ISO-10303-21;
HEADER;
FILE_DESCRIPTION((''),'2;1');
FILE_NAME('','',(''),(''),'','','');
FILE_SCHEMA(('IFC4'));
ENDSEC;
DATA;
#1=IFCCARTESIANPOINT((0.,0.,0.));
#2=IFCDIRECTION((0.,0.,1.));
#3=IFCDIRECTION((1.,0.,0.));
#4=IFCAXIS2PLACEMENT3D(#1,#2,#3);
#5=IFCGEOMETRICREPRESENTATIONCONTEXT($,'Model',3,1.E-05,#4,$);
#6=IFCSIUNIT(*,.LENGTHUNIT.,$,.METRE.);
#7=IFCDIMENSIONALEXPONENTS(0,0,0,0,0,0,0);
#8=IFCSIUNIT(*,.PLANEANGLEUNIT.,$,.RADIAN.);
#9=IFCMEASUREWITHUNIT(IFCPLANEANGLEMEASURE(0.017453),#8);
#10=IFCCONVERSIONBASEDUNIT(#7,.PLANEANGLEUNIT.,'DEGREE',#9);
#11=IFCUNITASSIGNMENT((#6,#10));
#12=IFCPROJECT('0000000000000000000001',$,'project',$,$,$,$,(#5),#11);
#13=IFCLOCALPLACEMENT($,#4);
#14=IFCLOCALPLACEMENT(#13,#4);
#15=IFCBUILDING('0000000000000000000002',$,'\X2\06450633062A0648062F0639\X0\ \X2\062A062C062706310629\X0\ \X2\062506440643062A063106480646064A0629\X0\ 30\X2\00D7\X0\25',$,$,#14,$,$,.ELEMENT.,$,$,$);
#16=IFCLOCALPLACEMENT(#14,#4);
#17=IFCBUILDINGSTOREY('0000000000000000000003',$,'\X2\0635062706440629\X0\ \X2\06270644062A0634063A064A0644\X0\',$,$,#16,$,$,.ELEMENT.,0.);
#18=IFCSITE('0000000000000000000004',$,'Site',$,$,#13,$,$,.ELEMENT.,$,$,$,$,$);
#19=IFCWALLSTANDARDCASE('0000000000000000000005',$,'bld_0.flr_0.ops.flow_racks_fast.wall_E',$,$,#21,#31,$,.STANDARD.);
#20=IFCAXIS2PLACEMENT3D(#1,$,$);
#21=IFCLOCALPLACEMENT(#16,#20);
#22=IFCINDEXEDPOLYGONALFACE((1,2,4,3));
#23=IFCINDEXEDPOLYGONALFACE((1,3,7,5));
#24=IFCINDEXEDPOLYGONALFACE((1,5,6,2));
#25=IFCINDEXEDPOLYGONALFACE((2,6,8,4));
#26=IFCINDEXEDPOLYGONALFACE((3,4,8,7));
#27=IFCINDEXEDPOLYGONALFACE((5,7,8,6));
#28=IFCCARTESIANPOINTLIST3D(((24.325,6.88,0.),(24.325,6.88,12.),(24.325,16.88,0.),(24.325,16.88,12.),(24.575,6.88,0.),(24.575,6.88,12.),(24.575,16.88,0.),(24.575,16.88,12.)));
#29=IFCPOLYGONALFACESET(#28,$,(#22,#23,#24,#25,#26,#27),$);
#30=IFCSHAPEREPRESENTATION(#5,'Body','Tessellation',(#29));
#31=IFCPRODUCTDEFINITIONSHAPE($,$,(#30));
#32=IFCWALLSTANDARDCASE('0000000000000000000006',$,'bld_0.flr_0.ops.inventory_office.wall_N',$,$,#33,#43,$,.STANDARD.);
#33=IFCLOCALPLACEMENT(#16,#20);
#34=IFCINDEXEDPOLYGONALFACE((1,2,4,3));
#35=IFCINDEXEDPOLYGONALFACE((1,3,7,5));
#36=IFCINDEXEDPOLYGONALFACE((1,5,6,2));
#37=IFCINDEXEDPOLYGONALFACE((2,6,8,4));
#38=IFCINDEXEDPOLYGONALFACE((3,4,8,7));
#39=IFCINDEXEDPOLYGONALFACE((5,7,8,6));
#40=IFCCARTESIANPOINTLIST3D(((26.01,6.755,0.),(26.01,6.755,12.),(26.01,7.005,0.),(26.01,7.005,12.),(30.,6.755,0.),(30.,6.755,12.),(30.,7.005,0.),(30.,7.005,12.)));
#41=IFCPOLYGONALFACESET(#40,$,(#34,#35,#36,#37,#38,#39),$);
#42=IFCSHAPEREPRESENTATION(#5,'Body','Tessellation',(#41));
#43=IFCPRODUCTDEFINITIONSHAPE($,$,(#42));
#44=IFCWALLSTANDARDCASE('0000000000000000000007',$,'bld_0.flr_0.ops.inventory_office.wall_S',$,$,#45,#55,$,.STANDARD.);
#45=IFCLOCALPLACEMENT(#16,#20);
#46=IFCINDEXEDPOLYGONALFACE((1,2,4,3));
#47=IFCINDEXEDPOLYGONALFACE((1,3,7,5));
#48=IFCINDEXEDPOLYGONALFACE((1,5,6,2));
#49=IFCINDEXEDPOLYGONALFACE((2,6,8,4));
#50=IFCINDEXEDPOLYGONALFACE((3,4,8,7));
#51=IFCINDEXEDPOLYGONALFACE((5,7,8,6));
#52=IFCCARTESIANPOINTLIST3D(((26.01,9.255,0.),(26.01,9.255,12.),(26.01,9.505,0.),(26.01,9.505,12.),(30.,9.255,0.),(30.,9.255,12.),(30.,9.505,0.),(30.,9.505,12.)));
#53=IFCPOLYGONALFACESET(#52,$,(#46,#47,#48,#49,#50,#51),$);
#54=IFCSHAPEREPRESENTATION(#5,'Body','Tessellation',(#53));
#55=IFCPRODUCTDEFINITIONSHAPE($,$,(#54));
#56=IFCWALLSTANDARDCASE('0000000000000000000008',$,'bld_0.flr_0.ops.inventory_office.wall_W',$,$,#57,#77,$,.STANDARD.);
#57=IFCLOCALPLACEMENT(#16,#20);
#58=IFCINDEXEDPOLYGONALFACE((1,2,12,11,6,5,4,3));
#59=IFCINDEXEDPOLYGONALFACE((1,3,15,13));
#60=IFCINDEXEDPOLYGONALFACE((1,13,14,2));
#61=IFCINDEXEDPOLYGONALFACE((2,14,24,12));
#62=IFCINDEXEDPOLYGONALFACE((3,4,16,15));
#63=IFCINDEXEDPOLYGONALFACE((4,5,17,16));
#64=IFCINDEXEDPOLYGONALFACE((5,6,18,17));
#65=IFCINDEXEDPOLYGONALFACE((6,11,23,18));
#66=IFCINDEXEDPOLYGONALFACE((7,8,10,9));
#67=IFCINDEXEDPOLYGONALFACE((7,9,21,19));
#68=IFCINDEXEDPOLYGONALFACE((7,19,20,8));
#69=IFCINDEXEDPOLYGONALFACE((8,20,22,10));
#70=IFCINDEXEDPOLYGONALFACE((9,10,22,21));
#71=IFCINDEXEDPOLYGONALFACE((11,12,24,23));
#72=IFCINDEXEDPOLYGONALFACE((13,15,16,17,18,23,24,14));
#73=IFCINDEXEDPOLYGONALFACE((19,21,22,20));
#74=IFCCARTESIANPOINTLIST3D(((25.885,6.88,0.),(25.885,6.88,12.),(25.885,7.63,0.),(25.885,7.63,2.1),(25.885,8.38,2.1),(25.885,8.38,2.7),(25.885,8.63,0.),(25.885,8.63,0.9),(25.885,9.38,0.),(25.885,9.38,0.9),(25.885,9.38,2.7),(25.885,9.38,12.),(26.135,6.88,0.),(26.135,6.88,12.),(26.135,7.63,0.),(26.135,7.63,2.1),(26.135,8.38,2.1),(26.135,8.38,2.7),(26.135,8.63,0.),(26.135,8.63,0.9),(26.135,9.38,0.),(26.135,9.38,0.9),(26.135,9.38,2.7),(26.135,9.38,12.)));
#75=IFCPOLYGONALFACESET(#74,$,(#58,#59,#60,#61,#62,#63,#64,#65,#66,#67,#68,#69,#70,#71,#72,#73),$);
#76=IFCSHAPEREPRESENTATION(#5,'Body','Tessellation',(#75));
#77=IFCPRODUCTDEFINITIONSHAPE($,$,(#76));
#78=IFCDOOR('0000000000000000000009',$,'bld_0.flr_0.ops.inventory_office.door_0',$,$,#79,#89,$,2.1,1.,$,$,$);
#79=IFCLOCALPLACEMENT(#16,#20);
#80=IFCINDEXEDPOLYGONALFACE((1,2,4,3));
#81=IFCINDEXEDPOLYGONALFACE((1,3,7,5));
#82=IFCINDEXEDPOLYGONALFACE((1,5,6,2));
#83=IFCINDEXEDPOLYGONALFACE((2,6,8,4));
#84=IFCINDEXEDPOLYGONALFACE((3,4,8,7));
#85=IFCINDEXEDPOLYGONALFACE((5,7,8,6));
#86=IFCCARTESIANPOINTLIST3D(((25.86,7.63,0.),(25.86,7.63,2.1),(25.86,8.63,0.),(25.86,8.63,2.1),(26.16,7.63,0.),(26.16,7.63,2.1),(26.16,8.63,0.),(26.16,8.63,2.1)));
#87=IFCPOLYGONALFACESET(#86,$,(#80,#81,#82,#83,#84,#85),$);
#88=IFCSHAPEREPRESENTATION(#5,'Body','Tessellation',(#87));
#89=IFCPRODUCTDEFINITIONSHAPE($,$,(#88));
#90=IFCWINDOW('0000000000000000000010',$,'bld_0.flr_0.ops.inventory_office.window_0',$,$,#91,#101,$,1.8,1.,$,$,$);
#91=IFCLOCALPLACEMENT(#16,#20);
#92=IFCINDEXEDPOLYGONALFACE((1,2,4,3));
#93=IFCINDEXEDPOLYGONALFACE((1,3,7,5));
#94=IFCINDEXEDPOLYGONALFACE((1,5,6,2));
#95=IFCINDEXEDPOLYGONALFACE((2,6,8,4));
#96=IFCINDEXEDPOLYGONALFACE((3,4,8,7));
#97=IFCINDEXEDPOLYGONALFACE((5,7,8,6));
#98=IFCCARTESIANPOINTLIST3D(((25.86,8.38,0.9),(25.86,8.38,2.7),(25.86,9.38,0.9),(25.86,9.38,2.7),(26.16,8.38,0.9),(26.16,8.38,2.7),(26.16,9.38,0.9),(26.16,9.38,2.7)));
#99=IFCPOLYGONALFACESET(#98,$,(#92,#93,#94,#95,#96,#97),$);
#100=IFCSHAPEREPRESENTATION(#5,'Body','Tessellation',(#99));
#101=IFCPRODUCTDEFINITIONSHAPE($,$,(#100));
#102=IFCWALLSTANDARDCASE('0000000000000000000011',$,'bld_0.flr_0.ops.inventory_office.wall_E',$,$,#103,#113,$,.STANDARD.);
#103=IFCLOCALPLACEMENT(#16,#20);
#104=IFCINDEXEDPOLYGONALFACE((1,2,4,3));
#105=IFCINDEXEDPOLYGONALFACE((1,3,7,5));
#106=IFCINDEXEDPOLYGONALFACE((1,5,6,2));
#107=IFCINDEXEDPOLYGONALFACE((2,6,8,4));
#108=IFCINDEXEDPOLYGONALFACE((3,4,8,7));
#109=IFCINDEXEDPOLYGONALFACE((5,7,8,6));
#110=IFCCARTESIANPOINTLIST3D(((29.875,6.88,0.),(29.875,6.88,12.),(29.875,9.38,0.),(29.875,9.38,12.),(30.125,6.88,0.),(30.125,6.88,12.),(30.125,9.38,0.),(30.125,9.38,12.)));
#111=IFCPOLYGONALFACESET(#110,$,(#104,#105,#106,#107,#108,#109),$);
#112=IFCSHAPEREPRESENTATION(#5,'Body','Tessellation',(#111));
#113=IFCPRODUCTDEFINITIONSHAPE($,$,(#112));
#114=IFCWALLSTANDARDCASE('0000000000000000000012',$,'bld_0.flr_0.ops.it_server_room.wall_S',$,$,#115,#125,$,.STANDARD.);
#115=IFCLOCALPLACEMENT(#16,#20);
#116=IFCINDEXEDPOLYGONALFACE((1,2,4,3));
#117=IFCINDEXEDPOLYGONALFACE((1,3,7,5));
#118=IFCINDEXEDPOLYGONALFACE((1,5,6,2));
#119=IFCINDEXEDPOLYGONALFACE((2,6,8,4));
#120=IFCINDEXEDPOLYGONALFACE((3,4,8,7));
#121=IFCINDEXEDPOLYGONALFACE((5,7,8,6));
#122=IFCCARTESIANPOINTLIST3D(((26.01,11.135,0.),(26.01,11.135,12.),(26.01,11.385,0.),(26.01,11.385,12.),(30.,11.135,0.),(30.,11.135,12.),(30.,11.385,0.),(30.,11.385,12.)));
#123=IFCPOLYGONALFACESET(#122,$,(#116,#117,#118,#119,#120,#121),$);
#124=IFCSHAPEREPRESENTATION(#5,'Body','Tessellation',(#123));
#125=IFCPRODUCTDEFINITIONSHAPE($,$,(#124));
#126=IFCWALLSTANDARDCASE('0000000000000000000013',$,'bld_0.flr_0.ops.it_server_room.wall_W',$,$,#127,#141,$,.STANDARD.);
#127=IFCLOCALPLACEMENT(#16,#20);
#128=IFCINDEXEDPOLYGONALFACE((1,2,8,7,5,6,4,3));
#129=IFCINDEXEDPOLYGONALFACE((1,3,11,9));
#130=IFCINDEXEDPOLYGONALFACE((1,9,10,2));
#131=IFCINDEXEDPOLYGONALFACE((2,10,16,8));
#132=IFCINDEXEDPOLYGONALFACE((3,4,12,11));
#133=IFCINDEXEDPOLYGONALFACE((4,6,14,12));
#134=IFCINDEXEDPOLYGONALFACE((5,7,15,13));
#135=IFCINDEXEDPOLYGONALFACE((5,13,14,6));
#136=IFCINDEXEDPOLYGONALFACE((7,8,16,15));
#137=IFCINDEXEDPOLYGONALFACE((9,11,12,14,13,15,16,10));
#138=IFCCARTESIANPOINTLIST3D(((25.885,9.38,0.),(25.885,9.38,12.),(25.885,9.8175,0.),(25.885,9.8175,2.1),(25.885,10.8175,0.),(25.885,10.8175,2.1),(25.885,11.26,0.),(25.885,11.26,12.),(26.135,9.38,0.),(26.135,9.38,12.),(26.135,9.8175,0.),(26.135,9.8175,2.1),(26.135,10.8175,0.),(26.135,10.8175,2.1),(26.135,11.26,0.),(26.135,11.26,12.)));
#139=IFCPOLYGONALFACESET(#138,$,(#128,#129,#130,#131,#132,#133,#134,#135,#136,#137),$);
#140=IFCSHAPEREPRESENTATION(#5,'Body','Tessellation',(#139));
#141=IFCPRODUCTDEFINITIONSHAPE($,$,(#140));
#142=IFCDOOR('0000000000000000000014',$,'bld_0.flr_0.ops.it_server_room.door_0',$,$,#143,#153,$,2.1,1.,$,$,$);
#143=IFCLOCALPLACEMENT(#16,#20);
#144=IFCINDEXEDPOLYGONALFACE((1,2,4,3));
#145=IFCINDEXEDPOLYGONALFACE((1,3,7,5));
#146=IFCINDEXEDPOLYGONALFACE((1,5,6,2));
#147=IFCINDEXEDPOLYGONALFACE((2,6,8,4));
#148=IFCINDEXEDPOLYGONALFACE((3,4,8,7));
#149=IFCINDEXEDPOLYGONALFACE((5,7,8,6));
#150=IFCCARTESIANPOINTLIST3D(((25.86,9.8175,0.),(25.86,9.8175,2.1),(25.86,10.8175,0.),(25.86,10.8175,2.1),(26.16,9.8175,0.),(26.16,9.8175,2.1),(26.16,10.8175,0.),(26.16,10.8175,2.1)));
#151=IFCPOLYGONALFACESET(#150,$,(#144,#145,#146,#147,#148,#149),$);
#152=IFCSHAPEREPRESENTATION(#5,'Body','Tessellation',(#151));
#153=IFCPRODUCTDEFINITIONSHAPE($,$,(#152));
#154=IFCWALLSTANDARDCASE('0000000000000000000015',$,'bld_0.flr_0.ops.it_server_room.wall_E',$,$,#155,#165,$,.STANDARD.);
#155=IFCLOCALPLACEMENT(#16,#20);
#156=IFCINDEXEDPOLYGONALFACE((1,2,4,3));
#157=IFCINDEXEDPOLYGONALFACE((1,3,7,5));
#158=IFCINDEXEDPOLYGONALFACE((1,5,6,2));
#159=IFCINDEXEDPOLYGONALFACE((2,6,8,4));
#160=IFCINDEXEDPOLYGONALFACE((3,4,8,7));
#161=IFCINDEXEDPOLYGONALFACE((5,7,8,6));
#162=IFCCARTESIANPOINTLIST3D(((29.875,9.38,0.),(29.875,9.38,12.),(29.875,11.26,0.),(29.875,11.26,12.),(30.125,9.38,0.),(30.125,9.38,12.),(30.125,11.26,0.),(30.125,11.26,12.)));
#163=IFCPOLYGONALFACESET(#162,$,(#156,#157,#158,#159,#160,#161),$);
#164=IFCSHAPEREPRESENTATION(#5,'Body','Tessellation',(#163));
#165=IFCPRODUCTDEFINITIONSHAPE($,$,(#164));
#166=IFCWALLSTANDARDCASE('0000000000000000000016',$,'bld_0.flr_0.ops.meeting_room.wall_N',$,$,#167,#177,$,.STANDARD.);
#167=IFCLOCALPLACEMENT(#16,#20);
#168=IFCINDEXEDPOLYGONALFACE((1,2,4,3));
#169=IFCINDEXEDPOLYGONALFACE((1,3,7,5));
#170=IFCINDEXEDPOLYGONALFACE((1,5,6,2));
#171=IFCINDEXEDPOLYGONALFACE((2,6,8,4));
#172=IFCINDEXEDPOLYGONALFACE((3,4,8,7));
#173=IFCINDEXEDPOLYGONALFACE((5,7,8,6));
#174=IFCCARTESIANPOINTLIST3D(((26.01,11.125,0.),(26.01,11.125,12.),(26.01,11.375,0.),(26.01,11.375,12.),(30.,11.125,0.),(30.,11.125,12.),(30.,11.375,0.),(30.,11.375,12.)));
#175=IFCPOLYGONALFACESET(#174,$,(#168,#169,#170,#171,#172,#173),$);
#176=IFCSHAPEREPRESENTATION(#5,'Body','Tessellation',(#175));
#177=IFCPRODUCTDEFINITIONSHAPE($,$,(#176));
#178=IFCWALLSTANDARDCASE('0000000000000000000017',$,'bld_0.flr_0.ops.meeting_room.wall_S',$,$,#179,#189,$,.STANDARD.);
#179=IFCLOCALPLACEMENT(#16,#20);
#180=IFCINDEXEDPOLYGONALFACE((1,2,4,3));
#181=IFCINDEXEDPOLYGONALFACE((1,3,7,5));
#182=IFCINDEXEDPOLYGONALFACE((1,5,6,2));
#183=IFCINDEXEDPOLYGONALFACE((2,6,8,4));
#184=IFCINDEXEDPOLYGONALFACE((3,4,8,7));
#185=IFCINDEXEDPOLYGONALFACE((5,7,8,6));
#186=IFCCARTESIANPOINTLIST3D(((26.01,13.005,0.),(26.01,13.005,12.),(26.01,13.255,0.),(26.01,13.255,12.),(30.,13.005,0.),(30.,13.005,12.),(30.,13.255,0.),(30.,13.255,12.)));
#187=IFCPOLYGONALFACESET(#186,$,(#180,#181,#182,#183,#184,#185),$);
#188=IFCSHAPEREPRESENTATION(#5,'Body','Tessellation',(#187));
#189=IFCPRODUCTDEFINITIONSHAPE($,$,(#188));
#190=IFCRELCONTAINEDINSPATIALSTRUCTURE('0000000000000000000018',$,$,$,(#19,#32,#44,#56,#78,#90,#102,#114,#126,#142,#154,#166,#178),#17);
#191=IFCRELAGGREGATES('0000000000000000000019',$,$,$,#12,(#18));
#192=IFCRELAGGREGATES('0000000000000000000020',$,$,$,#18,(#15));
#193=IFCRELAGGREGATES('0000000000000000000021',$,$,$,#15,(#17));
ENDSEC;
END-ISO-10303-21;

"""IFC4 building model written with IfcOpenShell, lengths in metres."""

from ifc_helpers import new_model, entity, si_unit, converted_unit, frame, frame_2d, origin_with_axes, origin_2d_with_axis, place, context, project, spatial, rectangle, extrude, element, fill, save


model = new_model("IFC4")

# Units and contexts
model_context = context("Model", 3, precision=1e-05, world=origin_with_axes())
ifc_project = project(units=[si_unit("LENGTHUNIT", "METRE"), converted_unit("PLANEANGLEUNIT", "DEGREE", entity("IfcPlaneAngleMeasure", 0.017453), si_unit("PLANEANGLEUNIT", "RADIAN"), dimensions=[0, 0, 0, 0, 0, 0, 0])], contexts=[model_context])

# Site, building, storey
site_placement = place(None, origin_with_axes())
site = spatial("IfcSite", under=ifc_project, at=site_placement, Name="Site", CompositionType="ELEMENT")
building_placement = place(site_placement, origin_with_axes())
building = spatial("IfcBuilding", under=site, at=building_placement, Name="مستودع تجارة إلكترونية 30×25", CompositionType="ELEMENT")
storey_placement = place(building_placement, origin_with_axes())
storey = spatial("IfcBuildingStorey", under=building, at=storey_placement, Name="صالة التشغيل", CompositionType="ELEMENT", Elevation=0.0)

# Walls
wall_1_placement = place(storey_placement, frame((24.45, 6.88, 0.0), z_axis=(0.0, 0.0, 1.0), x_axis=(0.0, 1.0, 0.0)))
element("IfcWallStandardCase", 1, at=wall_1_placement, inside=storey, Name="bld_0.flr_0.ops.flow_racks_fast.wall_E", PredefinedType="STANDARD", context=model_context, shape_type="SweptSolid", body=[
    extrude(rectangle(XDim=10.0, YDim=0.25, at=frame_2d((5.0, 0.0), x_axis=(1.0, 0.0))), origin_with_axes(), (0.0, 0.0, 1.0), 12.0),
])
for number, where, z_axis, x_axis, name in (
    (2, (26.01, 6.88, 0.0), (0.0, 0.0, 1.0), (1.0, 0.0, 0.0), "bld_0.flr_0.ops.inventory_office.wall_N"),
    (3, (26.01, 9.38, 0.0), (0.0, 0.0, 1.0), (1.0, 0.0, 0.0), "bld_0.flr_0.ops.inventory_office.wall_S"),
):
    element("IfcWallStandardCase", number, at=place(storey_placement, frame(where, z_axis=z_axis, x_axis=x_axis)), inside=storey, Name=name, PredefinedType="STANDARD", context=model_context, shape_type="SweptSolid", body=[
        extrude(rectangle(XDim=3.99, YDim=0.25, at=frame_2d((1.995, 0.0), x_axis=(1.0, 0.0))), origin_with_axes(), (0.0, 0.0, 1.0), 12.0),
    ])

# Wall, openings, door, window
wall_2_placement = place(storey_placement, frame((26.01, 6.88, 0.0), z_axis=(0.0, 0.0, 1.0), x_axis=(0.0, 1.0, 0.0)))
wall_2 = element("IfcWallStandardCase", 4, at=wall_2_placement, inside=storey, Name="bld_0.flr_0.ops.inventory_office.wall_W", PredefinedType="STANDARD", context=model_context, shape_type="SweptSolid", body=[
    extrude(rectangle(XDim=2.5, YDim=0.25, at=frame_2d((1.25, 0.0), x_axis=(1.0, 0.0))), origin_with_axes(), (0.0, 0.0, 1.0), 12.0),
])
opening_1_placement = place(storey_placement, frame((26.01, 8.13, 0.0), z_axis=(0.0, 0.0, 1.0), x_axis=(0.0, 1.0, 0.0)))
opening_1 = element("IfcOpeningElement", 5, at=opening_1_placement, cuts=wall_2, PredefinedType="OPENING", context=model_context, shape_type="SweptSolid", body=[
    extrude(rectangle(XDim=1.0, YDim=0.3, at=origin_2d_with_axis()), origin_with_axes(), (0.0, 0.0, 1.0), 2.1),
])
opening_2_placement = place(storey_placement, frame((26.01, 8.88, 0.9), z_axis=(0.0, 0.0, 1.0), x_axis=(0.0, 1.0, 0.0)))
opening_2 = element("IfcOpeningElement", 6, at=opening_2_placement, cuts=wall_2, PredefinedType="OPENING", context=model_context, shape_type="SweptSolid", body=[
    extrude(rectangle(XDim=1.0, YDim=0.3, at=origin_2d_with_axis()), origin_with_axes(), (0.0, 0.0, 1.0), 1.8),
])
door_1_placement = place(storey_placement, frame((26.01, 8.13, 0.0), z_axis=(0.0, 0.0, 1.0), x_axis=(0.0, 1.0, 0.0)))
door_1 = element("IfcDoor", 7, at=door_1_placement, inside=storey, Name="bld_0.flr_0.ops.inventory_office.door_0", OverallHeight=2.1, OverallWidth=1.0, context=model_context, shape_type="SweptSolid", body=[
    extrude(rectangle(XDim=1.0, YDim=0.3, at=origin_2d_with_axis()), origin_with_axes(), (0.0, 0.0, 1.0), 2.1),
])
fill(opening_1, door_1)
window_placement = place(storey_placement, frame((26.01, 8.88, 0.9), z_axis=(0.0, 0.0, 1.0), x_axis=(0.0, 1.0, 0.0)))
window = element("IfcWindow", 8, at=window_placement, inside=storey, Name="bld_0.flr_0.ops.inventory_office.window_0", OverallHeight=1.8, OverallWidth=1.0, context=model_context, shape_type="SweptSolid", body=[
    extrude(rectangle(XDim=1.0, YDim=0.3, at=origin_2d_with_axis()), origin_with_axes(), (0.0, 0.0, 1.0), 1.8),
])
fill(opening_2, window)

# Walls
wall_3_placement = place(storey_placement, frame((30.0, 6.88, 0.0), z_axis=(0.0, 0.0, 1.0), x_axis=(0.0, 1.0, 0.0)))
element("IfcWallStandardCase", 9, at=wall_3_placement, inside=storey, Name="bld_0.flr_0.ops.inventory_office.wall_E", PredefinedType="STANDARD", context=model_context, shape_type="SweptSolid", body=[
    extrude(rectangle(XDim=2.5, YDim=0.25, at=frame_2d((1.25, 0.0), x_axis=(1.0, 0.0))), origin_with_axes(), (0.0, 0.0, 1.0), 12.0),
])
for number, where, z_axis, x_axis, name in (
    (10, (26.01, 11.26, 0.0), (0.0, 0.0, 1.0), (1.0, 0.0, 0.0), "bld_0.flr_0.ops.it_server_room.wall_S"),
):
    element("IfcWallStandardCase", number, at=place(storey_placement, frame(where, z_axis=z_axis, x_axis=x_axis)), inside=storey, Name=name, PredefinedType="STANDARD", context=model_context, shape_type="SweptSolid", body=[
        extrude(rectangle(XDim=3.99, YDim=0.25, at=frame_2d((1.995, 0.0), x_axis=(1.0, 0.0))), origin_with_axes(), (0.0, 0.0, 1.0), 12.0),
    ])

# Wall, opening, door
wall_4_placement = place(storey_placement, frame((26.01, 9.38, 0.0), z_axis=(0.0, 0.0, 1.0), x_axis=(0.0, 1.0, 0.0)))
wall_4 = element("IfcWallStandardCase", 11, at=wall_4_placement, inside=storey, Name="bld_0.flr_0.ops.it_server_room.wall_W", PredefinedType="STANDARD", context=model_context, shape_type="SweptSolid", body=[
    extrude(rectangle(XDim=1.88, YDim=0.25, at=frame_2d((0.94, 0.0), x_axis=(1.0, 0.0))), origin_with_axes(), (0.0, 0.0, 1.0), 12.0),
])
opening_3_placement = place(storey_placement, frame((26.01, 10.3175, 0.0), z_axis=(0.0, 0.0, 1.0), x_axis=(0.0, 1.0, 0.0)))
opening_3 = element("IfcOpeningElement", 12, at=opening_3_placement, cuts=wall_4, PredefinedType="OPENING", context=model_context, shape_type="SweptSolid", body=[
    extrude(rectangle(XDim=1.0, YDim=0.3, at=origin_2d_with_axis()), origin_with_axes(), (0.0, 0.0, 1.0), 2.1),
])
door_2_placement = place(storey_placement, frame((26.01, 10.3175, 0.0), z_axis=(0.0, 0.0, 1.0), x_axis=(0.0, 1.0, 0.0)))
door_2 = element("IfcDoor", 13, at=door_2_placement, inside=storey, Name="bld_0.flr_0.ops.it_server_room.door_0", OverallHeight=2.1, OverallWidth=1.0, context=model_context, shape_type="SweptSolid", body=[
    extrude(rectangle(XDim=1.0, YDim=0.3, at=origin_2d_with_axis()), origin_with_axes(), (0.0, 0.0, 1.0), 2.1),
])
fill(opening_3, door_2)

# Walls
wall_5_placement = place(storey_placement, frame((30.0, 9.38, 0.0), z_axis=(0.0, 0.0, 1.0), x_axis=(0.0, 1.0, 0.0)))
element("IfcWallStandardCase", 14, at=wall_5_placement, inside=storey, Name="bld_0.flr_0.ops.it_server_room.wall_E", PredefinedType="STANDARD", context=model_context, shape_type="SweptSolid", body=[
    extrude(rectangle(XDim=1.88, YDim=0.25, at=frame_2d((0.94, 0.0), x_axis=(1.0, 0.0))), origin_with_axes(), (0.0, 0.0, 1.0), 12.0),
])
for number, where, z_axis, x_axis, name in (
    (15, (26.01, 11.25, 0.0), (0.0, 0.0, 1.0), (1.0, 0.0, 0.0), "bld_0.flr_0.ops.meeting_room.wall_N"),
    (16, (26.01, 13.13, 0.0), (0.0, 0.0, 1.0), (1.0, 0.0, 0.0), "bld_0.flr_0.ops.meeting_room.wall_S"),
):
    element("IfcWallStandardCase", number, at=place(storey_placement, frame(where, z_axis=z_axis, x_axis=x_axis)), inside=storey, Name=name, PredefinedType="STANDARD", context=model_context, shape_type="SweptSolid", body=[
        extrude(rectangle(XDim=3.99, YDim=0.25, at=frame_2d((1.995, 0.0), x_axis=(1.0, 0.0))), origin_with_axes(), (0.0, 0.0, 1.0), 12.0),
    ])

save(model, "model.ifc")
